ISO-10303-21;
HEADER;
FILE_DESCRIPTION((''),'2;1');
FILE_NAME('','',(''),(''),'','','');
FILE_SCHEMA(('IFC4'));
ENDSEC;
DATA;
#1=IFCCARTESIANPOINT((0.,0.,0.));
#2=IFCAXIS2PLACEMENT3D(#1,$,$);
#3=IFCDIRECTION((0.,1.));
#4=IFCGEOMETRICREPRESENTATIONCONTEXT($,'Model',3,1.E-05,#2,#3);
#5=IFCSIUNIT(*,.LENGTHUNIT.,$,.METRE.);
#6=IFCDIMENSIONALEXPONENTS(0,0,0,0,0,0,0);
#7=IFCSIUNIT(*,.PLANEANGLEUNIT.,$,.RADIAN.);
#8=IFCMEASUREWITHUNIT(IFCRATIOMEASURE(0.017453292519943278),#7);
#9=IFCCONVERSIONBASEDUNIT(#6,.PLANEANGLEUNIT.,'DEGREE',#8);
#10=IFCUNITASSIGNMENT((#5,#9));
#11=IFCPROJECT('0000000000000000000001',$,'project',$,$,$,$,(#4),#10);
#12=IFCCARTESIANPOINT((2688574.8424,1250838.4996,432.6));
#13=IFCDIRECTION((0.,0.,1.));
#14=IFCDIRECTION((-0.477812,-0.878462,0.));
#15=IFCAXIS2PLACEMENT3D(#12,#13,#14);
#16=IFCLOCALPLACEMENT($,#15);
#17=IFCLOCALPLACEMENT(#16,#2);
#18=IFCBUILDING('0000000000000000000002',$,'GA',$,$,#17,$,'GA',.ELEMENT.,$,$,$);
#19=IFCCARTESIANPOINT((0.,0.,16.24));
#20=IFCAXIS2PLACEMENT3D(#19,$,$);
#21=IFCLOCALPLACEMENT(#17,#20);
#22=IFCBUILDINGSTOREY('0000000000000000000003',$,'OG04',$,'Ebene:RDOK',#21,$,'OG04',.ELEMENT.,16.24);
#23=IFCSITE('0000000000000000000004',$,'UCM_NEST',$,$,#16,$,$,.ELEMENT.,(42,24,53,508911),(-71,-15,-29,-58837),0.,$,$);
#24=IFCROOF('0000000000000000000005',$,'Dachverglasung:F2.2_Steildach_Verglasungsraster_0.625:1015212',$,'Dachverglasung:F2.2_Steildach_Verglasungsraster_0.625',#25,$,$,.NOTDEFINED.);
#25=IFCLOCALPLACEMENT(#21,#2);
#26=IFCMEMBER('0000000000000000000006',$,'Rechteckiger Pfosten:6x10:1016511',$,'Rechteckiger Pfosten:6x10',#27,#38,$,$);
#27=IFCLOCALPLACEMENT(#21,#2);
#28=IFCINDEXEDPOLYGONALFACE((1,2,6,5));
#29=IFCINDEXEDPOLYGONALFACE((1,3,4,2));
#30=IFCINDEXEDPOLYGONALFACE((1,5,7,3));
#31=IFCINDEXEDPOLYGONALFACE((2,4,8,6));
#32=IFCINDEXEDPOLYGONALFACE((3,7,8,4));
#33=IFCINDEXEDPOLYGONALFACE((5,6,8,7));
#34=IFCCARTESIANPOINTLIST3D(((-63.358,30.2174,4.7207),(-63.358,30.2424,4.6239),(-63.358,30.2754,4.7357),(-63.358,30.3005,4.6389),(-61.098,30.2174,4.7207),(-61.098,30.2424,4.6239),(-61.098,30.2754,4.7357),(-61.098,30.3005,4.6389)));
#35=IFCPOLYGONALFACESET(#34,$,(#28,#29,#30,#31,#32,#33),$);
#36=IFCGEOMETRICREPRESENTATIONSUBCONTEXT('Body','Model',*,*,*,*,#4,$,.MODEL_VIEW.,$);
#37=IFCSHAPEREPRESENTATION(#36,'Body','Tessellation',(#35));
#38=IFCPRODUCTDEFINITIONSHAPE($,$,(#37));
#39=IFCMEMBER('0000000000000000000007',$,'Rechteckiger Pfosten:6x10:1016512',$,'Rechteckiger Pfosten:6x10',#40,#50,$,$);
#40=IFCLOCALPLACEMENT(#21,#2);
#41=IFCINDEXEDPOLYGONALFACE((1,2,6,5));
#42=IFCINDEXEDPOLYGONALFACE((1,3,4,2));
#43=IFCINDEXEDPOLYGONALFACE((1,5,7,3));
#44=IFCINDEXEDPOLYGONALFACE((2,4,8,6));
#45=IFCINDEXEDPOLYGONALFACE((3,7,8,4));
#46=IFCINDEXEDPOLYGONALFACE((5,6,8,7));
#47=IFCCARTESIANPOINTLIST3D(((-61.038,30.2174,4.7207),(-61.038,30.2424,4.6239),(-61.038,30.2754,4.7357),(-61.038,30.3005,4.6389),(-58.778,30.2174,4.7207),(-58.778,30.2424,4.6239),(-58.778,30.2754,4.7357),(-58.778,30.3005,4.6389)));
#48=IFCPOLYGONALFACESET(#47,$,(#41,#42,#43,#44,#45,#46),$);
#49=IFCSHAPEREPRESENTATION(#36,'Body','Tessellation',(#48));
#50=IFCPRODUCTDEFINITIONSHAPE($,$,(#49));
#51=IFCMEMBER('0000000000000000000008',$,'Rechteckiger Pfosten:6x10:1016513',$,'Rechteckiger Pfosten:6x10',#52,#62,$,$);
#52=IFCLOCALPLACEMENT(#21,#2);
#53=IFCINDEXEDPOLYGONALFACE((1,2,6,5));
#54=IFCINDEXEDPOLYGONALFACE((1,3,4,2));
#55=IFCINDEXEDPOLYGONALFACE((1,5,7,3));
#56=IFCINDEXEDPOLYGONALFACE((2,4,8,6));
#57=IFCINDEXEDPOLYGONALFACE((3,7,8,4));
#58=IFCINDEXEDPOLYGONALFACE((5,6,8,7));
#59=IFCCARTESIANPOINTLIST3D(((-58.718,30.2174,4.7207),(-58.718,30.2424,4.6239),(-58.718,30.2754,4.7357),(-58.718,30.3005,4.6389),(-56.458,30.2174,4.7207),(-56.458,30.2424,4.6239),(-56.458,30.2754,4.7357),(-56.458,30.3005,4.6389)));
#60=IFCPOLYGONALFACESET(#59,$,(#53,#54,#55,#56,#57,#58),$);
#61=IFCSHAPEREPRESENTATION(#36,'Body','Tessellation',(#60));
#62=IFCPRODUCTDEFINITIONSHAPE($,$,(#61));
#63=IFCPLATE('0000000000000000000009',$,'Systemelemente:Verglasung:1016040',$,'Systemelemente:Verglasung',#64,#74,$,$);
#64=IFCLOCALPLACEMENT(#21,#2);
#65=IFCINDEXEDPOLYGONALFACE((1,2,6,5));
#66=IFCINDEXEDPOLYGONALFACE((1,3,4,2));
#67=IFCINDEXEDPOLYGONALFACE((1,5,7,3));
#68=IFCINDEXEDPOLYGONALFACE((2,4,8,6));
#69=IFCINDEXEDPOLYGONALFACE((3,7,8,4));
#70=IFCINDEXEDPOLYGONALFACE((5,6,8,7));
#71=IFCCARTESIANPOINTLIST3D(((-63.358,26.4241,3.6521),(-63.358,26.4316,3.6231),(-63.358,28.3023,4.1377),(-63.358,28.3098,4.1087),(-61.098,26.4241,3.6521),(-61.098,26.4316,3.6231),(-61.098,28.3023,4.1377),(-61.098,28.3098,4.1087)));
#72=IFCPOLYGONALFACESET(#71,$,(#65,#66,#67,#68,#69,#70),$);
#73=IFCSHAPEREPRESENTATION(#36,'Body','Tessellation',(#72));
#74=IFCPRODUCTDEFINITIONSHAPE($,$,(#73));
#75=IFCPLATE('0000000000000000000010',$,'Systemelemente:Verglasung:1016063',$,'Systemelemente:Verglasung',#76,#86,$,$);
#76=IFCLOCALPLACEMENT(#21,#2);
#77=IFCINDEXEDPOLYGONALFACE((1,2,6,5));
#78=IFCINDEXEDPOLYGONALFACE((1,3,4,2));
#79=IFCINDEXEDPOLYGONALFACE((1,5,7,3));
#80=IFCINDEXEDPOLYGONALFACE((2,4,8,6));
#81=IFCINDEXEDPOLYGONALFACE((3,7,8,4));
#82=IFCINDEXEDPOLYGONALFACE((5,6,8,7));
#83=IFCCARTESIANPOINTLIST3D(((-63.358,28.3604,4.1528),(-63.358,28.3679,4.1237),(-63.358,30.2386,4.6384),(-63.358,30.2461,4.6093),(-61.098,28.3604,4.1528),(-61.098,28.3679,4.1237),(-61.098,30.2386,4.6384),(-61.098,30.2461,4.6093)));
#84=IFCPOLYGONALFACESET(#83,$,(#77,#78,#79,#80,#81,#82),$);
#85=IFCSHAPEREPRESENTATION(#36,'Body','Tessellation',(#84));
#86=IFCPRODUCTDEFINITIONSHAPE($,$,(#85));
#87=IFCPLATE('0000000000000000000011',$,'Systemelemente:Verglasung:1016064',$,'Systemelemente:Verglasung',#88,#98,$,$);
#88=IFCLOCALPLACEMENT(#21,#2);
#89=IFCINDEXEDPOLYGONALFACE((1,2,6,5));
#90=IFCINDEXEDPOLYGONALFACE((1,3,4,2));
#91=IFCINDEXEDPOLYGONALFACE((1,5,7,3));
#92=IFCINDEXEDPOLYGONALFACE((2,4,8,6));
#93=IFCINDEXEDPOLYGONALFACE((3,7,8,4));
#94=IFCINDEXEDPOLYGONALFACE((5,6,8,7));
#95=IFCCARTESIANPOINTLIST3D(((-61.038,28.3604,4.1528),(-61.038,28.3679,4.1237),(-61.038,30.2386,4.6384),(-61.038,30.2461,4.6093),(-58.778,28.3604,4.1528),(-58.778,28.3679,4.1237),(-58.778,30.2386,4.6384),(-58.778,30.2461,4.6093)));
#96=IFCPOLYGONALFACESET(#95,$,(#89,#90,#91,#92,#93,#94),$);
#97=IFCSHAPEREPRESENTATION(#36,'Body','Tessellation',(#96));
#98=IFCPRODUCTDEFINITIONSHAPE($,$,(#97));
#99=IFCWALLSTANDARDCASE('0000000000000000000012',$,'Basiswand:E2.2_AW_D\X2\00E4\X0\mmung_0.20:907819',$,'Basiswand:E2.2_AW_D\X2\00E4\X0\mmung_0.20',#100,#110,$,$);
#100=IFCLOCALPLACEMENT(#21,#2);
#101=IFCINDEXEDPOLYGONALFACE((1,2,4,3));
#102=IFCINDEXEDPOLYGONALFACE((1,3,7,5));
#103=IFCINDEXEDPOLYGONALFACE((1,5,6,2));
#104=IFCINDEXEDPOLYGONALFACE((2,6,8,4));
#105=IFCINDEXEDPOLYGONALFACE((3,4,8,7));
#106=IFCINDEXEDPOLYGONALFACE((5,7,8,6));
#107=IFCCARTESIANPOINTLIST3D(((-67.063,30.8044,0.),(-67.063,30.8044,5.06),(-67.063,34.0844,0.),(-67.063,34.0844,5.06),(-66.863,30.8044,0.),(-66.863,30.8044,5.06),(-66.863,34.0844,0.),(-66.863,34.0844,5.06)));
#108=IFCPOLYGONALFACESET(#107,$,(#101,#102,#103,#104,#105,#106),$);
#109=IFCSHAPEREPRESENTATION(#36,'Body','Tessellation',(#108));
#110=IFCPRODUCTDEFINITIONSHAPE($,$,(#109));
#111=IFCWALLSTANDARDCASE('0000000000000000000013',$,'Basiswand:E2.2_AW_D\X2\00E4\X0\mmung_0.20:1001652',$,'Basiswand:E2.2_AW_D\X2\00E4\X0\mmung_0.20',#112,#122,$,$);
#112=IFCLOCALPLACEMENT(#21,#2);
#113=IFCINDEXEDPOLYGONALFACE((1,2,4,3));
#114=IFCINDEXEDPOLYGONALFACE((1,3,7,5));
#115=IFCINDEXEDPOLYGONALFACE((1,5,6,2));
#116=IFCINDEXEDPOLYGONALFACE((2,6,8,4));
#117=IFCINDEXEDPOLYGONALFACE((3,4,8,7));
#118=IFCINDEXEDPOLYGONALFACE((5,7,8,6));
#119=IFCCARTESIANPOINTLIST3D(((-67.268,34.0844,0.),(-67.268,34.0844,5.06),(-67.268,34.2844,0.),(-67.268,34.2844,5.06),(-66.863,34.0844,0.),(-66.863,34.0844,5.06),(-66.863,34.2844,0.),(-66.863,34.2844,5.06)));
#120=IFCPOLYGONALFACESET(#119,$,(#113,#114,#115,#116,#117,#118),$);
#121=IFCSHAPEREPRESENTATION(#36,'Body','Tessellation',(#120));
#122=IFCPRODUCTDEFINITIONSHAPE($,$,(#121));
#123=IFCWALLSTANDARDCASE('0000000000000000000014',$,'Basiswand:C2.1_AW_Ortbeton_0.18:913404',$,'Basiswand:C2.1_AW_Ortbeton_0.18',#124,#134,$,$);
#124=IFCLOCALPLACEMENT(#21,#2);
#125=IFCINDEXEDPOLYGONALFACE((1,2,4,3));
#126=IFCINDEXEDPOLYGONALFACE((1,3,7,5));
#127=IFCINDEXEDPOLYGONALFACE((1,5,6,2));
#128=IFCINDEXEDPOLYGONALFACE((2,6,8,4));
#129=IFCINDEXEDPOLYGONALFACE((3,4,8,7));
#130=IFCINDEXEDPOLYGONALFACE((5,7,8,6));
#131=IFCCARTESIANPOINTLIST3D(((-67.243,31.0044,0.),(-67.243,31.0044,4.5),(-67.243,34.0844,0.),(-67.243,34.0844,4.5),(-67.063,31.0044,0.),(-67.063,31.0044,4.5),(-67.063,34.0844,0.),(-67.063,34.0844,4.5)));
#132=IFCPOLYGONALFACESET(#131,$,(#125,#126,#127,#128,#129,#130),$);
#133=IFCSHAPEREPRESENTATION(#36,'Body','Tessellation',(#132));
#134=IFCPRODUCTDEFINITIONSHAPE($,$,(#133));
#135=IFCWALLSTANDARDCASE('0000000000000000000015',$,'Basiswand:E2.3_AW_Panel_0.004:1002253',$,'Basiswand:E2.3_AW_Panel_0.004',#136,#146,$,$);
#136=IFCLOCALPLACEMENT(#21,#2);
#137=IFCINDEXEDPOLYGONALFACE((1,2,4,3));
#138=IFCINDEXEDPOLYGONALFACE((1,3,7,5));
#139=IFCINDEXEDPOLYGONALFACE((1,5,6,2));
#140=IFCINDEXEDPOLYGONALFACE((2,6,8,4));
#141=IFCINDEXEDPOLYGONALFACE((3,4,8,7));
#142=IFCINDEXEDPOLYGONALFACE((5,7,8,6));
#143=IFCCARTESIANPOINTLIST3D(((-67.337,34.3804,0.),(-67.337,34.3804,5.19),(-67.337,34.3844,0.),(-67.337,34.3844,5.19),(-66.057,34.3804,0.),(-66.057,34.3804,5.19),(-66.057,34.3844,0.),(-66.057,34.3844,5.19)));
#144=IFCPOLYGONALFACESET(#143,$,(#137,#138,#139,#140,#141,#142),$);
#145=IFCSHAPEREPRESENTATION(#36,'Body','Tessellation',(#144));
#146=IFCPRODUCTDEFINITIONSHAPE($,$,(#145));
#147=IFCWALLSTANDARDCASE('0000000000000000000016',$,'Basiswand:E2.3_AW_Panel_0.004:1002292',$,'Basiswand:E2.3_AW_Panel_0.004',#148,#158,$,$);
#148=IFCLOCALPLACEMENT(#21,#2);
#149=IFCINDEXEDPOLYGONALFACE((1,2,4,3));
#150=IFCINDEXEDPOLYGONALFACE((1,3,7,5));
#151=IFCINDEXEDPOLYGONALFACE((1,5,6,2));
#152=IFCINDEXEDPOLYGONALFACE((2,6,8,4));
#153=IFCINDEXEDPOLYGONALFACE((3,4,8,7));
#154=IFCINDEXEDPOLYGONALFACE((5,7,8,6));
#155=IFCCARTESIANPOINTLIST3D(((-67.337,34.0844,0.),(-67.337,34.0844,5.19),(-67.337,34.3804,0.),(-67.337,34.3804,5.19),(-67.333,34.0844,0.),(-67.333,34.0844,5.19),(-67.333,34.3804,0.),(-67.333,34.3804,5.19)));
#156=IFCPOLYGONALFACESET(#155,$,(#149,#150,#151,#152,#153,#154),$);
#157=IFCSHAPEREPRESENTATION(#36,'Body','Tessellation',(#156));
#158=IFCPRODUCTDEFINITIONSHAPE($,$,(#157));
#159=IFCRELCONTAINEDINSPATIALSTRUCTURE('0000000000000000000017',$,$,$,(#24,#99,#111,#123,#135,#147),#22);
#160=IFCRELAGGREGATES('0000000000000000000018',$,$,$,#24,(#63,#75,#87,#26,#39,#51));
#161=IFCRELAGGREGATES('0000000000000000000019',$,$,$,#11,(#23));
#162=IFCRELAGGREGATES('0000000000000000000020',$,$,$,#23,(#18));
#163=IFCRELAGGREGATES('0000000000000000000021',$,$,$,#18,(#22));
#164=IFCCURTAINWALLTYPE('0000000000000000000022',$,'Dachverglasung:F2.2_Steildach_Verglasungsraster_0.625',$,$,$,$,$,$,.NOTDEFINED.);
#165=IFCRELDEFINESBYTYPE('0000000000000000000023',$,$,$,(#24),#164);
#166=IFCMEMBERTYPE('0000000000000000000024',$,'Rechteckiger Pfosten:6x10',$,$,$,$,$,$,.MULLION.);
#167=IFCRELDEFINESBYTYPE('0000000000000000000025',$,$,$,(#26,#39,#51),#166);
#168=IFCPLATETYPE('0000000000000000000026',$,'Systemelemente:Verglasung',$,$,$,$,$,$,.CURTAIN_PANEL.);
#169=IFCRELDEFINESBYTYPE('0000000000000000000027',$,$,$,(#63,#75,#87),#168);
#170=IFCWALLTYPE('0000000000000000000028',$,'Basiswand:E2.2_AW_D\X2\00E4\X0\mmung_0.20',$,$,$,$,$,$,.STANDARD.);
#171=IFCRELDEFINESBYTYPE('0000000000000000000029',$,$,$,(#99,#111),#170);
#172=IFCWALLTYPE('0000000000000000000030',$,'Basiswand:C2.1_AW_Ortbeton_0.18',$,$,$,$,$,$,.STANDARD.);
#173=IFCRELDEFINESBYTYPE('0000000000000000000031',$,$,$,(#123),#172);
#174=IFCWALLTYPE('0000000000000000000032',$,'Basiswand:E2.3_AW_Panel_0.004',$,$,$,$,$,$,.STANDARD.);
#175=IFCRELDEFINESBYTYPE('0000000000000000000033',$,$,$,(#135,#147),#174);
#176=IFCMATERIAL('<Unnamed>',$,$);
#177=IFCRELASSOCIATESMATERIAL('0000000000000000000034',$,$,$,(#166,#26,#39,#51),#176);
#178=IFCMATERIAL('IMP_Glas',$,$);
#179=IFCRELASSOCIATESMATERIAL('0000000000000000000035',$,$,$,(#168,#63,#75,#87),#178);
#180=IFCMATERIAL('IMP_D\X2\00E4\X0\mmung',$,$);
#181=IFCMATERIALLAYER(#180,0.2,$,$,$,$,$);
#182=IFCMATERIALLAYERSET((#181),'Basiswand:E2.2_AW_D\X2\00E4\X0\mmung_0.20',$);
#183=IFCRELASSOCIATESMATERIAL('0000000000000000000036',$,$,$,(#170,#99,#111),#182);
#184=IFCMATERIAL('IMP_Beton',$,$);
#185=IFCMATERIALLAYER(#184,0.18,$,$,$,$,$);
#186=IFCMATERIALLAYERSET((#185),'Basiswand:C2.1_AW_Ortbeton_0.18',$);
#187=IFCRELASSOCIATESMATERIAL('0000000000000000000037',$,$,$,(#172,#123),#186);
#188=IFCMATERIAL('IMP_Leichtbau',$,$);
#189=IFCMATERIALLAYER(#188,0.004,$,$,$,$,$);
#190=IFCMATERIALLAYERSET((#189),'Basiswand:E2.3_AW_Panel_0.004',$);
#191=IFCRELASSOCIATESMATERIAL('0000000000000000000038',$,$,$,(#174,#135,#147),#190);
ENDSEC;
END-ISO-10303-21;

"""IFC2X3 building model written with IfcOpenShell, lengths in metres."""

from ifc_helpers import new_model, entity, si_unit, converted_unit, direction, frame, frame_2d, origin, origin_2d_with_axis, place, context, subcontext, project, spatial, rectangle, extrude, source, transform, mapped, material, layer, layer_set, layer_usage, type_object, type_shapes, element, aggregate, save


model = new_model("IFC2X3")

# Units and contexts
model_context = context("Model", 3, precision=1e-05, world=origin(), true_north=direction((0.0, 1.0)))
body_context = subcontext(model_context, "Body", "Model", "MODEL_VIEW")
ifc_project = project(units=[si_unit("LENGTHUNIT", "METRE"), converted_unit("PLANEANGLEUNIT", "DEGREE", entity("IfcRatioMeasure", 0.017453292519943278), si_unit("PLANEANGLEUNIT", "RADIAN"), dimensions=[0, 0, 0, 0, 0, 0, 0])], contexts=[model_context])

# Site, building, storey
site_placement = place(None, frame((2688574.8424, 1250838.4996, 432.6), z_axis=(0.0, 0.0, 1.0), x_axis=(-0.477812, -0.878462, 0.0)))
site = spatial("IfcSite", under=ifc_project, at=site_placement, Name="UCM_NEST", CompositionType="ELEMENT", RefLatitude=(42, 24, 53, 508911), RefLongitude=(-71, -15, -29, -58837), RefElevation=0.0)
building_placement = place(site_placement, origin())
building = spatial("IfcBuilding", under=site, at=building_placement, Name="GA", LongName="GA", CompositionType="ELEMENT")
storey_placement = place(building_placement, frame((0.0, 0.0, 16.24)))
storey = spatial("IfcBuildingStorey", under=building, at=storey_placement, Name="OG04", ObjectType="Ebene:RDOK", LongName="OG04", CompositionType="ELEMENT", Elevation=16.24)

# Roof, members, plates
curtain_wall_type = type_object("IfcCurtainWallType", Name="Dachverglasung:F2.2_Steildach_Verglasungsraster_0.625", PredefinedType="NOTDEFINED")
roof_placement = place(storey_placement, frame((0.0, 0.0, -16.24)))
roof = element("IfcRoof", 1, at=roof_placement, inside=storey, type_object=curtain_wall_type, Name="Dachverglasung:F2.2_Steildach_Verglasungsraster_0.625:1015212", ObjectType="Dachverglasung:F2.2_Steildach_Verglasungsraster_0.625", ShapeType="NOTDEFINED")
ifc_material_1 = material(Name="<Unnamed>")
member_type_1 = type_object("IfcMemberType", Name="Rechteckiger Pfosten:6x10", PredefinedType="MULLION", material=ifc_material_1)
shared_shape_1 = source(origin(), body_context, "Body", "SweptSolid", [
    extrude(rectangle(XDim=0.1, YDim=0.06, at=origin_2d_with_axis()), frame((-0.03, -0.05, -2.26), z_axis=(0.0, 0.0, 1.0), x_axis=(0.0, -1.0, 0.0)), (0.0, 0.0, 1.0), 2.26),
])
type_shapes(member_type_1, [shared_shape_1])
member_1_placement = place(roof_placement, frame((-63.358, 30.3005, 20.8789), z_axis=(-1.0, 0.0, 0.0), x_axis=(0.0, 0.968163, 0.250322)))
member_1 = element("IfcMember", 2, at=member_1_placement, type_object=member_type_1, material=ifc_material_1, Name="Rechteckiger Pfosten:6x10:1016511", ObjectType="Rechteckiger Pfosten:6x10", context=body_context, shape_type="MappedRepresentation", body=[
    mapped(shared_shape_1, transform((0.0, 0.0, 0.0), scale=1.0)),
])
member_2_placement = place(roof_placement, frame((-61.038, 30.3005, 20.8789), z_axis=(-1.0, 0.0, 0.0), x_axis=(0.0, 0.968163, 0.250322)))
member_2 = element("IfcMember", 3, at=member_2_placement, type_object=member_type_1, material=ifc_material_1, Name="Rechteckiger Pfosten:6x10:1016512", ObjectType="Rechteckiger Pfosten:6x10", context=body_context, shape_type="MappedRepresentation", body=[
    mapped(shared_shape_1, transform((0.0, 0.0, 0.0), scale=1.0)),
])
member_3_placement = place(roof_placement, frame((-58.718, 30.3005, 20.8789), z_axis=(-1.0, 0.0, 0.0), x_axis=(0.0, 0.968163, 0.250322)))
member_3 = element("IfcMember", 4, at=member_3_placement, type_object=member_type_1, material=ifc_material_1, Name="Rechteckiger Pfosten:6x10:1016513", ObjectType="Rechteckiger Pfosten:6x10", context=body_context, shape_type="MappedRepresentation", body=[
    mapped(shared_shape_1, transform((0.0, 0.0, 0.0), scale=1.0)),
])
ifc_material_2 = material(Name="IMP_Glas")
plate_type = type_object("IfcPlateType", Name="Systemelemente:Verglasung", PredefinedType="CURTAIN_PANEL", material=ifc_material_2)
shared_shape_2 = source(origin(), body_context, "Body", "SweptSolid", [
    extrude(rectangle(XDim=0.03, YDim=2.26, at=origin_2d_with_axis()), frame((0.0, 0.0, 0.0), z_axis=(0.0, 0.0, 1.0), x_axis=(0.0, 1.0, 0.0)), (0.0, 0.0, 1.0), 1.94),
])
type_shapes(plate_type, [shared_shape_2])
plate_1_placement = place(roof_placement, frame((-62.228, 26.4278, 19.8776), z_axis=(0.0, 0.968163, 0.250322), x_axis=(1.0, 0.0, 0.0)))
plate_1 = element("IfcPlate", 5, at=plate_1_placement, type_object=plate_type, material=ifc_material_2, Name="Systemelemente:Verglasung:1016040", ObjectType="Systemelemente:Verglasung", context=body_context, shape_type="MappedRepresentation", body=[
    mapped(shared_shape_2, transform((0.0, 0.0, 0.0), scale=1.0)),
])
plate_2_placement = place(roof_placement, frame((-62.228, 28.3642, 20.3782), z_axis=(0.0, 0.968163, 0.250322), x_axis=(1.0, 0.0, 0.0)))
plate_2 = element("IfcPlate", 6, at=plate_2_placement, type_object=plate_type, material=ifc_material_2, Name="Systemelemente:Verglasung:1016063", ObjectType="Systemelemente:Verglasung", context=body_context, shape_type="MappedRepresentation", body=[
    mapped(shared_shape_2, transform((0.0, 0.0, 0.0), scale=1.0)),
])
plate_3_placement = place(roof_placement, frame((-59.908, 28.3642, 20.3782), z_axis=(0.0, 0.968163, 0.250322), x_axis=(1.0, 0.0, 0.0)))
plate_3 = element("IfcPlate", 7, at=plate_3_placement, type_object=plate_type, material=ifc_material_2, Name="Systemelemente:Verglasung:1016064", ObjectType="Systemelemente:Verglasung", context=body_context, shape_type="MappedRepresentation", body=[
    mapped(shared_shape_2, transform((0.0, 0.0, 0.0), scale=1.0)),
])
aggregate(roof, [plate_1, plate_2, plate_3, member_1, member_2, member_3])

# Walls
ifc_material_3 = material(Name="IMP_Dämmung")
ifc_layer_1 = layer(ifc_material_3, 0.2)
ifc_layer_set_1 = layer_set([ifc_layer_1], Name="Basiswand:E2.2_AW_Dämmung_0.20")
ifc_layer_usage_1 = layer_usage(ifc_layer_set_1, "AXIS2", "NEGATIVE", 0.1)
wall_type_1 = type_object("IfcWallType", Name="Basiswand:E2.2_AW_Dämmung_0.20", PredefinedType="STANDARD", material=ifc_layer_set_1)
wall_1_placement = place(storey_placement, frame((-66.963, 34.0844, 0.0), z_axis=(0.0, 0.0, 1.0), x_axis=(0.0, -1.0, 0.0)))
element("IfcWallStandardCase", 8, at=wall_1_placement, inside=storey, type_object=wall_type_1, material=ifc_layer_usage_1, Name="Basiswand:E2.2_AW_Dämmung_0.20:907819", ObjectType="Basiswand:E2.2_AW_Dämmung_0.20", context=body_context, shape_type="SweptSolid", body=[
    extrude(rectangle(XDim=3.28, YDim=0.2, at=frame_2d((1.64, 0.0), x_axis=(-1.0, 0.0))), origin(), (0.0, 0.0, 1.0), 5.06),
])
ifc_layer_usage_2 = layer_usage(ifc_layer_set_1, "AXIS2", "POSITIVE", -0.1)
wall_2_placement = place(storey_placement, frame((-66.863, 34.1844, 0.0), z_axis=(0.0, 0.0, 1.0), x_axis=(-1.0, 0.0, 0.0)))
element("IfcWallStandardCase", 9, at=wall_2_placement, inside=storey, type_object=wall_type_1, material=ifc_layer_usage_2, Name="Basiswand:E2.2_AW_Dämmung_0.20:1001652", ObjectType="Basiswand:E2.2_AW_Dämmung_0.20", context=body_context, shape_type="SweptSolid", body=[
    extrude(rectangle(XDim=0.405, YDim=0.2, at=frame_2d((0.2025, 0.0), x_axis=(-1.0, 0.0))), origin(), (0.0, 0.0, 1.0), 5.06),
])
ifc_material_4 = material(Name="IMP_Beton")
ifc_layer_2 = layer(ifc_material_4, 0.18)
ifc_layer_set_2 = layer_set([ifc_layer_2], Name="Basiswand:C2.1_AW_Ortbeton_0.18")
ifc_layer_usage_3 = layer_usage(ifc_layer_set_2, "AXIS2", "NEGATIVE", 0.09)
wall_type_2 = type_object("IfcWallType", Name="Basiswand:C2.1_AW_Ortbeton_0.18", PredefinedType="STANDARD", material=ifc_layer_set_2)
wall_3_placement = place(storey_placement, frame((-67.153, 34.0844, 0.0), z_axis=(0.0, 0.0, 1.0), x_axis=(0.0, -1.0, 0.0)))
element("IfcWallStandardCase", 10, at=wall_3_placement, inside=storey, type_object=wall_type_2, material=ifc_layer_usage_3, Name="Basiswand:C2.1_AW_Ortbeton_0.18:913404", ObjectType="Basiswand:C2.1_AW_Ortbeton_0.18", context=body_context, shape_type="SweptSolid", body=[
    extrude(rectangle(XDim=3.08, YDim=0.18, at=frame_2d((1.54, 0.0), x_axis=(-1.0, 0.0))), origin(), (0.0, 0.0, 1.0), 4.5),
])
ifc_material_5 = material(Name="IMP_Leichtbau")
ifc_layer_3 = layer(ifc_material_5, 0.004)
ifc_layer_set_3 = layer_set([ifc_layer_3], Name="Basiswand:E2.3_AW_Panel_0.004")
ifc_layer_usage_4 = layer_usage(ifc_layer_set_3, "AXIS2", "NEGATIVE", 0.002)
wall_type_3 = type_object("IfcWallType", Name="Basiswand:E2.3_AW_Panel_0.004", PredefinedType="STANDARD", material=ifc_layer_set_3)
wall_4_placement = place(storey_placement, frame((-66.057, 34.3824, 0.0), z_axis=(0.0, 0.0, 1.0), x_axis=(-1.0, 0.0, 0.0)))
element("IfcWallStandardCase", 11, at=wall_4_placement, inside=storey, type_object=wall_type_3, material=ifc_layer_usage_4, Name="Basiswand:E2.3_AW_Panel_0.004:1002253", ObjectType="Basiswand:E2.3_AW_Panel_0.004", context=body_context, shape_type="SweptSolid", body=[
    extrude(rectangle(XDim=1.28, YDim=0.004, at=frame_2d((0.64, 0.0), x_axis=(-1.0, 0.0))), origin(), (0.0, 0.0, 1.0), 5.19),
])
wall_5_placement = place(storey_placement, frame((-67.335, 34.3804, 0.0), z_axis=(0.0, 0.0, 1.0), x_axis=(0.0, -1.0, 0.0)))
element("IfcWallStandardCase", 12, at=wall_5_placement, inside=storey, type_object=wall_type_3, material=ifc_layer_usage_4, Name="Basiswand:E2.3_AW_Panel_0.004:1002292", ObjectType="Basiswand:E2.3_AW_Panel_0.004", context=body_context, shape_type="SweptSolid", body=[
    extrude(rectangle(XDim=0.296, YDim=0.004, at=frame_2d((0.148, 0.0), x_axis=(-1.0, 0.0))), origin(), (0.0, 0.0, 1.0), 5.19),
])

save(model, "model.ifc")
